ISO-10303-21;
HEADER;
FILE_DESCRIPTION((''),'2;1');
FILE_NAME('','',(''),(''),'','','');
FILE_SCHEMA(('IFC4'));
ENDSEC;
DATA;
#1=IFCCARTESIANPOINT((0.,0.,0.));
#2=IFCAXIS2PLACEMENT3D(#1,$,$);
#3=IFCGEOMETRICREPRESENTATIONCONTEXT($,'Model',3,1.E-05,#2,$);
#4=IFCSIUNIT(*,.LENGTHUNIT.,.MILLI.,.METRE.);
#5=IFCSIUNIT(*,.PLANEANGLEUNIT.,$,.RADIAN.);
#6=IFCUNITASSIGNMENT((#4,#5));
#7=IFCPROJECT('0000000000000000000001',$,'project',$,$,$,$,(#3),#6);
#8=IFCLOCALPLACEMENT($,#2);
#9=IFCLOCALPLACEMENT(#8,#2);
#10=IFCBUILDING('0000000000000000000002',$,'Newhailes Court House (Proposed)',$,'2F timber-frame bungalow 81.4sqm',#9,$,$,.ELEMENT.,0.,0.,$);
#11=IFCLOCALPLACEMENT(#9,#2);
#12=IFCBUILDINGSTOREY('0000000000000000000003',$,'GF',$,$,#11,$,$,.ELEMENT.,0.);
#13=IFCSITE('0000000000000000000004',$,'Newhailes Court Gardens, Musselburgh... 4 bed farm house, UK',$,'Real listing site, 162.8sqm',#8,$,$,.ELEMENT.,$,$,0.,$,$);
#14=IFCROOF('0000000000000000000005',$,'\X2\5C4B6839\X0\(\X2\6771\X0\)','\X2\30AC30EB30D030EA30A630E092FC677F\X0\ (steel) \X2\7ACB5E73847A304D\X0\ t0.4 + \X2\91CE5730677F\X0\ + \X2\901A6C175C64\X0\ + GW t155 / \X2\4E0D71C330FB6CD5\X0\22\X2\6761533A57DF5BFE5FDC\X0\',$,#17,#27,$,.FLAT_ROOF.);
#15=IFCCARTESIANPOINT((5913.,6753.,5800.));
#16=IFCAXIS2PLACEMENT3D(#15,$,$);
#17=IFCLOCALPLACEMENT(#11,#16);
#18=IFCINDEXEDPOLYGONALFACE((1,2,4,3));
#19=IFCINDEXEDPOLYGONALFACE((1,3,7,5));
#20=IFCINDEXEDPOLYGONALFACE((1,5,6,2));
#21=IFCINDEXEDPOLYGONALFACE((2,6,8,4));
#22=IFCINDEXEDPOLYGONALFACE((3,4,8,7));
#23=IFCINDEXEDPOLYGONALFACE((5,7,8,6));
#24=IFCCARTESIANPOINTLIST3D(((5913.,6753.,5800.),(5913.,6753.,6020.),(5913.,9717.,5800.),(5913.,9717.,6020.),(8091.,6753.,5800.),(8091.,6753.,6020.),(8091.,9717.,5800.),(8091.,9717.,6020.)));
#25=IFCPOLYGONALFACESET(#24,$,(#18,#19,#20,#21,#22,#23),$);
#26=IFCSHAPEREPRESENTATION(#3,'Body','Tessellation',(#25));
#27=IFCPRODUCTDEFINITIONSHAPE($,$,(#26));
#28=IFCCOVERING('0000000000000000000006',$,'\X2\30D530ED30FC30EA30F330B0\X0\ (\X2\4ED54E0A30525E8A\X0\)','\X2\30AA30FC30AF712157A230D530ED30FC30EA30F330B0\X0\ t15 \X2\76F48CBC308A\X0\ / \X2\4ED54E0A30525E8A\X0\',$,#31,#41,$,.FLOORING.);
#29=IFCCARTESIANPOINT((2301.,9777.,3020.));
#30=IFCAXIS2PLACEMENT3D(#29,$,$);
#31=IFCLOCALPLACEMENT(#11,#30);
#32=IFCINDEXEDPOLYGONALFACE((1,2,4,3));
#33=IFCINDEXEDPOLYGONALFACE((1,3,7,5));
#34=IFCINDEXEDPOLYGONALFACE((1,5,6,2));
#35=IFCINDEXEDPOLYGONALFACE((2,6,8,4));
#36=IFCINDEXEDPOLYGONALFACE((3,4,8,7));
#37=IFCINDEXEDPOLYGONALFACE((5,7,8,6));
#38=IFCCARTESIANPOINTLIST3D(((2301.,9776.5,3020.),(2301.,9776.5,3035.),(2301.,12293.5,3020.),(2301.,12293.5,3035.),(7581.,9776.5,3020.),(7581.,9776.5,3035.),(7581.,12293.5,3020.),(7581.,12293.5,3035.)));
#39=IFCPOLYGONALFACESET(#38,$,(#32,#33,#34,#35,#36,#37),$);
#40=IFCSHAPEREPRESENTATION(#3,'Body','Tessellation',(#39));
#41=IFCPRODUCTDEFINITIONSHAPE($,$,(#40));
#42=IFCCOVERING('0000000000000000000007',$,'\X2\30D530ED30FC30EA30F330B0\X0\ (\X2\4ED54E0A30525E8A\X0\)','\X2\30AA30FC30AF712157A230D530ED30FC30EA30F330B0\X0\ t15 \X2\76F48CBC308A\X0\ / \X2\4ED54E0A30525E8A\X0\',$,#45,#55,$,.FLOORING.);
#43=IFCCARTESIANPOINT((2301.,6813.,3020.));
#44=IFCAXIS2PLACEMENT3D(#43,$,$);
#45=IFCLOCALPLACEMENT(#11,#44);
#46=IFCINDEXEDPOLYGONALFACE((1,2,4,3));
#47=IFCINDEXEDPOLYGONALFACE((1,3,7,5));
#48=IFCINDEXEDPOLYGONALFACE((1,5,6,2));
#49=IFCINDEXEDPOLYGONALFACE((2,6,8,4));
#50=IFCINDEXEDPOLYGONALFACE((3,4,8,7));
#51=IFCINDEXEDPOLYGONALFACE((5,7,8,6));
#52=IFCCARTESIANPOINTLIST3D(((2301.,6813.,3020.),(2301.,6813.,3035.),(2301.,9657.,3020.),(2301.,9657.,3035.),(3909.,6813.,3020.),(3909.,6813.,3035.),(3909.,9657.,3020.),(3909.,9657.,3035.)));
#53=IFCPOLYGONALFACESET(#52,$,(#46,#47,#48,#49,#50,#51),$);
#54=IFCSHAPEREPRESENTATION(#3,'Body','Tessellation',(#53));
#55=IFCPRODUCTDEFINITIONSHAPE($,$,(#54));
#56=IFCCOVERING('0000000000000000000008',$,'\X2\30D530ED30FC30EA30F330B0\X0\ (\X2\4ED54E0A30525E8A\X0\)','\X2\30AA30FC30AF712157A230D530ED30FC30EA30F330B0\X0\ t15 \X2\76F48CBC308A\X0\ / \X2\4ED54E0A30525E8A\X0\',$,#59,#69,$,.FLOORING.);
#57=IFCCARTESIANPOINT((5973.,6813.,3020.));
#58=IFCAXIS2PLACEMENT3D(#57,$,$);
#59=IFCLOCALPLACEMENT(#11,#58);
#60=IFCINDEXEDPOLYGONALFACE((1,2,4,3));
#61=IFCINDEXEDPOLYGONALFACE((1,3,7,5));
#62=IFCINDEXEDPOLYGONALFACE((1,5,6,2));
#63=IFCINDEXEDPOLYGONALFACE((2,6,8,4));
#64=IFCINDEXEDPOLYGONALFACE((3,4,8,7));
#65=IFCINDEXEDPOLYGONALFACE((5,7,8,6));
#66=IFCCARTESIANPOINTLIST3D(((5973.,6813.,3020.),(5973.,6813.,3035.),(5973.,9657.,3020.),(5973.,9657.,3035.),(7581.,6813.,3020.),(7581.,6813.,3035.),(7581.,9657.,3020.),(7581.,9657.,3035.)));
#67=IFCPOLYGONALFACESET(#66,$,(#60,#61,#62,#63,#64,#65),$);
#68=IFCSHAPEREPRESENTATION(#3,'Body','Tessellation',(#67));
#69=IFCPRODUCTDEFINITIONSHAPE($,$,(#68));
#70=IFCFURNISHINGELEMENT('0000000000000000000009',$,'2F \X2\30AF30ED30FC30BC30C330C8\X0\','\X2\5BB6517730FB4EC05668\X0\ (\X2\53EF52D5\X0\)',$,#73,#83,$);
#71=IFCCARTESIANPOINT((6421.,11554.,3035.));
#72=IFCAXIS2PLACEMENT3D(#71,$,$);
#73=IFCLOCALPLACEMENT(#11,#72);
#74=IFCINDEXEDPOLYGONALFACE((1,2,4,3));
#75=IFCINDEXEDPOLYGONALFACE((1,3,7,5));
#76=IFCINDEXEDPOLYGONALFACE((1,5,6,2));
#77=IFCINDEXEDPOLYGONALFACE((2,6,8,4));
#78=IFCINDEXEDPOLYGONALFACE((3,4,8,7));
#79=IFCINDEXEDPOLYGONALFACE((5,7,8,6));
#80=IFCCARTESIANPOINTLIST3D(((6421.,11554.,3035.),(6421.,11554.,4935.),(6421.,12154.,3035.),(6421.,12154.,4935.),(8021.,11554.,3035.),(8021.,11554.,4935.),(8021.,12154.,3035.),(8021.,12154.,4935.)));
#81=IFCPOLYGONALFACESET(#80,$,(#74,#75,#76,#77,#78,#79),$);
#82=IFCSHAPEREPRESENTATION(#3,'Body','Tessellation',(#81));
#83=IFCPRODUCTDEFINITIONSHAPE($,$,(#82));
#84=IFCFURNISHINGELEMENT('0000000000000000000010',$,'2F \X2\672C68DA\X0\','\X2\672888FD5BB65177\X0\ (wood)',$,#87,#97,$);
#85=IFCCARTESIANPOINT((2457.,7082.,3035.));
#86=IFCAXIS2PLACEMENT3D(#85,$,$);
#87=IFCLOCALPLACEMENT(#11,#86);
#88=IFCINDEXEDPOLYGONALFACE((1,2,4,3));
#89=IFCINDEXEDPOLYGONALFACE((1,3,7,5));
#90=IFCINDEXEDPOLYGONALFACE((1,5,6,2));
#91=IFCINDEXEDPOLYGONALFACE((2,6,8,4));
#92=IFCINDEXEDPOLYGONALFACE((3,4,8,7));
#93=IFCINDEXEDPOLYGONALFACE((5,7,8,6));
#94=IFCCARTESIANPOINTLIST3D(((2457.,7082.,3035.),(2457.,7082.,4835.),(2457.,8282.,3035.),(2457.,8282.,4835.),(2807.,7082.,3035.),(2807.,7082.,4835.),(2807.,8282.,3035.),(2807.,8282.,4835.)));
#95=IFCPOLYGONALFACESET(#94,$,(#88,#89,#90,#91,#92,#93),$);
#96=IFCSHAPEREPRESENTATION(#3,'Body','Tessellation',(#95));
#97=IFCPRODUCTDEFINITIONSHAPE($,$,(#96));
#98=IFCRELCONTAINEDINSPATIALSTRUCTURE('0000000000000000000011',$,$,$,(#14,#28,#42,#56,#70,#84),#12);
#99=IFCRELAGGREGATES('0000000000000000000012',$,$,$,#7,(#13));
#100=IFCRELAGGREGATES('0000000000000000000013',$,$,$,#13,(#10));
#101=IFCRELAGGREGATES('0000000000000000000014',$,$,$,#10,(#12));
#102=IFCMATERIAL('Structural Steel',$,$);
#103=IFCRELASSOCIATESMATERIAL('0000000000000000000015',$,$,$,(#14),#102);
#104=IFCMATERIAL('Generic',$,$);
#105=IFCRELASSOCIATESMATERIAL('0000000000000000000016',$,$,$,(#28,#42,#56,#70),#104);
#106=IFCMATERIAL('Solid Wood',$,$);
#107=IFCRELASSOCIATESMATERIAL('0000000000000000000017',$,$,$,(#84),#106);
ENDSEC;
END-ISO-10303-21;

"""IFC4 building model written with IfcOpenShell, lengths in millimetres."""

from ifc_helpers import new_model, si_unit, frame, frame_2d, origin, place, context, project, spatial, rectangle, extrude, material, element, save


model = new_model("IFC4")

# Units and contexts
model_context = context("Model", 3, precision=1e-05, world=origin())
ifc_project = project(units=[si_unit("LENGTHUNIT", "METRE", prefix="MILLI"), si_unit("PLANEANGLEUNIT", "RADIAN")], contexts=[model_context])

# Site, building, storey
site_placement = place(None, origin())
site = spatial("IfcSite", under=ifc_project, at=site_placement, Name="Newhailes Court Gardens, Musselburgh... 4 bed farm house, UK", ObjectType="Real listing site, 162.8sqm", CompositionType="ELEMENT", RefElevation=0.0)
building_placement = place(site_placement, origin())
building = spatial("IfcBuilding", under=site, at=building_placement, Name="Newhailes Court House (Proposed)", ObjectType="2F timber-frame bungalow 81.4sqm", CompositionType="ELEMENT", ElevationOfRefHeight=0.0, ElevationOfTerrain=0.0)
storey_placement = place(building_placement, origin())
storey = spatial("IfcBuildingStorey", under=building, at=storey_placement, Name="GF", CompositionType="ELEMENT", Elevation=0.0)

# Shared definitions
ifc_material_1 = material(Name="Solid Wood")

# Roof
ifc_material_2 = material(Name="Structural Steel")
roof_1_placement = place(storey_placement, frame((5913.0, 6753.0, 5800.0)))
element("IfcRoof", 1, at=roof_1_placement, inside=storey, material=ifc_material_2, Name="屋根(東)", Description="ガルバリウム鋼板 (steel) 立平葺き t0.4 + 野地板 + 通気層 + GW t155 / 不燃・法22条区域対応", PredefinedType="FLAT_ROOF", context=model_context, shape_type="SweptSolid", body=[
    extrude(rectangle(XDim=2178.0, YDim=2964.0, at=frame_2d((1089.0, 1482.0))), frame((5913.0, 6753.0, 5800.0)), (0.0, 0.0, 1.0), 220.0),
])

# Coverings
ifc_material_3 = material(Name="Generic")
covering_1_placement = place(storey_placement, frame((2301.0, 9777.0, 3020.0)))
element("IfcCovering", 2, at=covering_1_placement, inside=storey, material=ifc_material_3, Name="フローリング (仕上げ床)", Description="オーク無垢フローリング t15 直貼り / 仕上げ床", PredefinedType="FLOORING", context=model_context, shape_type="SweptSolid", body=[
    extrude(rectangle(XDim=5280.0, YDim=2517.0, at=frame_2d((2640.0, 1258.0))), frame((2301.0, 9777.0, 3020.0)), (0.0, 0.0, 1.0), 15.0),
])
covering_2_placement = place(storey_placement, frame((2301.0, 6813.0, 3020.0)))
element("IfcCovering", 3, at=covering_2_placement, inside=storey, material=ifc_material_3, Name="フローリング (仕上げ床)", Description="オーク無垢フローリング t15 直貼り / 仕上げ床", PredefinedType="FLOORING", context=model_context, shape_type="SweptSolid", body=[
    extrude(rectangle(XDim=1608.0, YDim=2844.0, at=frame_2d((804.0, 1422.0))), frame((2301.0, 6813.0, 3020.0)), (0.0, 0.0, 1.0), 15.0),
])
covering_3_placement = place(storey_placement, frame((5973.0, 6813.0, 3020.0)))
element("IfcCovering", 4, at=covering_3_placement, inside=storey, material=ifc_material_3, Name="フローリング (仕上げ床)", Description="オーク無垢フローリング t15 直貼り / 仕上げ床", PredefinedType="FLOORING", context=model_context, shape_type="SweptSolid", body=[
    extrude(rectangle(XDim=1608.0, YDim=2844.0, at=frame_2d((804.0, 1422.0))), frame((5973.0, 6813.0, 3020.0)), (0.0, 0.0, 1.0), 15.0),
])

# Furnishing elements
furnishing_1_placement = place(storey_placement, frame((6421.0, 11554.0, 3035.0)))
element("IfcFurnishingElement", 5, at=furnishing_1_placement, inside=storey, material=ifc_material_3, Name="2F クローゼット", Description="家具・什器 (可動)", context=model_context, shape_type="SweptSolid", body=[
    extrude(rectangle(XDim=1600.0, YDim=600.0, at=frame_2d((800.0, 300.0))), frame((6421.0, 11554.0, 3035.0)), (0.0, 0.0, 1.0), 1900.0),
])
furnishing_2_placement = place(storey_placement, frame((2457.0, 7082.0, 3035.0)))
element("IfcFurnishingElement", 6, at=furnishing_2_placement, inside=storey, material=ifc_material_1, Name="2F 本棚", Description="木製家具 (wood)", context=model_context, shape_type="SweptSolid", body=[
    extrude(rectangle(XDim=350.0, YDim=1200.0, at=frame_2d((175.0, 600.0))), frame((2457.0, 7082.0, 3035.0)), (0.0, 0.0, 1.0), 1800.0),
])

save(model, "model.ifc")
